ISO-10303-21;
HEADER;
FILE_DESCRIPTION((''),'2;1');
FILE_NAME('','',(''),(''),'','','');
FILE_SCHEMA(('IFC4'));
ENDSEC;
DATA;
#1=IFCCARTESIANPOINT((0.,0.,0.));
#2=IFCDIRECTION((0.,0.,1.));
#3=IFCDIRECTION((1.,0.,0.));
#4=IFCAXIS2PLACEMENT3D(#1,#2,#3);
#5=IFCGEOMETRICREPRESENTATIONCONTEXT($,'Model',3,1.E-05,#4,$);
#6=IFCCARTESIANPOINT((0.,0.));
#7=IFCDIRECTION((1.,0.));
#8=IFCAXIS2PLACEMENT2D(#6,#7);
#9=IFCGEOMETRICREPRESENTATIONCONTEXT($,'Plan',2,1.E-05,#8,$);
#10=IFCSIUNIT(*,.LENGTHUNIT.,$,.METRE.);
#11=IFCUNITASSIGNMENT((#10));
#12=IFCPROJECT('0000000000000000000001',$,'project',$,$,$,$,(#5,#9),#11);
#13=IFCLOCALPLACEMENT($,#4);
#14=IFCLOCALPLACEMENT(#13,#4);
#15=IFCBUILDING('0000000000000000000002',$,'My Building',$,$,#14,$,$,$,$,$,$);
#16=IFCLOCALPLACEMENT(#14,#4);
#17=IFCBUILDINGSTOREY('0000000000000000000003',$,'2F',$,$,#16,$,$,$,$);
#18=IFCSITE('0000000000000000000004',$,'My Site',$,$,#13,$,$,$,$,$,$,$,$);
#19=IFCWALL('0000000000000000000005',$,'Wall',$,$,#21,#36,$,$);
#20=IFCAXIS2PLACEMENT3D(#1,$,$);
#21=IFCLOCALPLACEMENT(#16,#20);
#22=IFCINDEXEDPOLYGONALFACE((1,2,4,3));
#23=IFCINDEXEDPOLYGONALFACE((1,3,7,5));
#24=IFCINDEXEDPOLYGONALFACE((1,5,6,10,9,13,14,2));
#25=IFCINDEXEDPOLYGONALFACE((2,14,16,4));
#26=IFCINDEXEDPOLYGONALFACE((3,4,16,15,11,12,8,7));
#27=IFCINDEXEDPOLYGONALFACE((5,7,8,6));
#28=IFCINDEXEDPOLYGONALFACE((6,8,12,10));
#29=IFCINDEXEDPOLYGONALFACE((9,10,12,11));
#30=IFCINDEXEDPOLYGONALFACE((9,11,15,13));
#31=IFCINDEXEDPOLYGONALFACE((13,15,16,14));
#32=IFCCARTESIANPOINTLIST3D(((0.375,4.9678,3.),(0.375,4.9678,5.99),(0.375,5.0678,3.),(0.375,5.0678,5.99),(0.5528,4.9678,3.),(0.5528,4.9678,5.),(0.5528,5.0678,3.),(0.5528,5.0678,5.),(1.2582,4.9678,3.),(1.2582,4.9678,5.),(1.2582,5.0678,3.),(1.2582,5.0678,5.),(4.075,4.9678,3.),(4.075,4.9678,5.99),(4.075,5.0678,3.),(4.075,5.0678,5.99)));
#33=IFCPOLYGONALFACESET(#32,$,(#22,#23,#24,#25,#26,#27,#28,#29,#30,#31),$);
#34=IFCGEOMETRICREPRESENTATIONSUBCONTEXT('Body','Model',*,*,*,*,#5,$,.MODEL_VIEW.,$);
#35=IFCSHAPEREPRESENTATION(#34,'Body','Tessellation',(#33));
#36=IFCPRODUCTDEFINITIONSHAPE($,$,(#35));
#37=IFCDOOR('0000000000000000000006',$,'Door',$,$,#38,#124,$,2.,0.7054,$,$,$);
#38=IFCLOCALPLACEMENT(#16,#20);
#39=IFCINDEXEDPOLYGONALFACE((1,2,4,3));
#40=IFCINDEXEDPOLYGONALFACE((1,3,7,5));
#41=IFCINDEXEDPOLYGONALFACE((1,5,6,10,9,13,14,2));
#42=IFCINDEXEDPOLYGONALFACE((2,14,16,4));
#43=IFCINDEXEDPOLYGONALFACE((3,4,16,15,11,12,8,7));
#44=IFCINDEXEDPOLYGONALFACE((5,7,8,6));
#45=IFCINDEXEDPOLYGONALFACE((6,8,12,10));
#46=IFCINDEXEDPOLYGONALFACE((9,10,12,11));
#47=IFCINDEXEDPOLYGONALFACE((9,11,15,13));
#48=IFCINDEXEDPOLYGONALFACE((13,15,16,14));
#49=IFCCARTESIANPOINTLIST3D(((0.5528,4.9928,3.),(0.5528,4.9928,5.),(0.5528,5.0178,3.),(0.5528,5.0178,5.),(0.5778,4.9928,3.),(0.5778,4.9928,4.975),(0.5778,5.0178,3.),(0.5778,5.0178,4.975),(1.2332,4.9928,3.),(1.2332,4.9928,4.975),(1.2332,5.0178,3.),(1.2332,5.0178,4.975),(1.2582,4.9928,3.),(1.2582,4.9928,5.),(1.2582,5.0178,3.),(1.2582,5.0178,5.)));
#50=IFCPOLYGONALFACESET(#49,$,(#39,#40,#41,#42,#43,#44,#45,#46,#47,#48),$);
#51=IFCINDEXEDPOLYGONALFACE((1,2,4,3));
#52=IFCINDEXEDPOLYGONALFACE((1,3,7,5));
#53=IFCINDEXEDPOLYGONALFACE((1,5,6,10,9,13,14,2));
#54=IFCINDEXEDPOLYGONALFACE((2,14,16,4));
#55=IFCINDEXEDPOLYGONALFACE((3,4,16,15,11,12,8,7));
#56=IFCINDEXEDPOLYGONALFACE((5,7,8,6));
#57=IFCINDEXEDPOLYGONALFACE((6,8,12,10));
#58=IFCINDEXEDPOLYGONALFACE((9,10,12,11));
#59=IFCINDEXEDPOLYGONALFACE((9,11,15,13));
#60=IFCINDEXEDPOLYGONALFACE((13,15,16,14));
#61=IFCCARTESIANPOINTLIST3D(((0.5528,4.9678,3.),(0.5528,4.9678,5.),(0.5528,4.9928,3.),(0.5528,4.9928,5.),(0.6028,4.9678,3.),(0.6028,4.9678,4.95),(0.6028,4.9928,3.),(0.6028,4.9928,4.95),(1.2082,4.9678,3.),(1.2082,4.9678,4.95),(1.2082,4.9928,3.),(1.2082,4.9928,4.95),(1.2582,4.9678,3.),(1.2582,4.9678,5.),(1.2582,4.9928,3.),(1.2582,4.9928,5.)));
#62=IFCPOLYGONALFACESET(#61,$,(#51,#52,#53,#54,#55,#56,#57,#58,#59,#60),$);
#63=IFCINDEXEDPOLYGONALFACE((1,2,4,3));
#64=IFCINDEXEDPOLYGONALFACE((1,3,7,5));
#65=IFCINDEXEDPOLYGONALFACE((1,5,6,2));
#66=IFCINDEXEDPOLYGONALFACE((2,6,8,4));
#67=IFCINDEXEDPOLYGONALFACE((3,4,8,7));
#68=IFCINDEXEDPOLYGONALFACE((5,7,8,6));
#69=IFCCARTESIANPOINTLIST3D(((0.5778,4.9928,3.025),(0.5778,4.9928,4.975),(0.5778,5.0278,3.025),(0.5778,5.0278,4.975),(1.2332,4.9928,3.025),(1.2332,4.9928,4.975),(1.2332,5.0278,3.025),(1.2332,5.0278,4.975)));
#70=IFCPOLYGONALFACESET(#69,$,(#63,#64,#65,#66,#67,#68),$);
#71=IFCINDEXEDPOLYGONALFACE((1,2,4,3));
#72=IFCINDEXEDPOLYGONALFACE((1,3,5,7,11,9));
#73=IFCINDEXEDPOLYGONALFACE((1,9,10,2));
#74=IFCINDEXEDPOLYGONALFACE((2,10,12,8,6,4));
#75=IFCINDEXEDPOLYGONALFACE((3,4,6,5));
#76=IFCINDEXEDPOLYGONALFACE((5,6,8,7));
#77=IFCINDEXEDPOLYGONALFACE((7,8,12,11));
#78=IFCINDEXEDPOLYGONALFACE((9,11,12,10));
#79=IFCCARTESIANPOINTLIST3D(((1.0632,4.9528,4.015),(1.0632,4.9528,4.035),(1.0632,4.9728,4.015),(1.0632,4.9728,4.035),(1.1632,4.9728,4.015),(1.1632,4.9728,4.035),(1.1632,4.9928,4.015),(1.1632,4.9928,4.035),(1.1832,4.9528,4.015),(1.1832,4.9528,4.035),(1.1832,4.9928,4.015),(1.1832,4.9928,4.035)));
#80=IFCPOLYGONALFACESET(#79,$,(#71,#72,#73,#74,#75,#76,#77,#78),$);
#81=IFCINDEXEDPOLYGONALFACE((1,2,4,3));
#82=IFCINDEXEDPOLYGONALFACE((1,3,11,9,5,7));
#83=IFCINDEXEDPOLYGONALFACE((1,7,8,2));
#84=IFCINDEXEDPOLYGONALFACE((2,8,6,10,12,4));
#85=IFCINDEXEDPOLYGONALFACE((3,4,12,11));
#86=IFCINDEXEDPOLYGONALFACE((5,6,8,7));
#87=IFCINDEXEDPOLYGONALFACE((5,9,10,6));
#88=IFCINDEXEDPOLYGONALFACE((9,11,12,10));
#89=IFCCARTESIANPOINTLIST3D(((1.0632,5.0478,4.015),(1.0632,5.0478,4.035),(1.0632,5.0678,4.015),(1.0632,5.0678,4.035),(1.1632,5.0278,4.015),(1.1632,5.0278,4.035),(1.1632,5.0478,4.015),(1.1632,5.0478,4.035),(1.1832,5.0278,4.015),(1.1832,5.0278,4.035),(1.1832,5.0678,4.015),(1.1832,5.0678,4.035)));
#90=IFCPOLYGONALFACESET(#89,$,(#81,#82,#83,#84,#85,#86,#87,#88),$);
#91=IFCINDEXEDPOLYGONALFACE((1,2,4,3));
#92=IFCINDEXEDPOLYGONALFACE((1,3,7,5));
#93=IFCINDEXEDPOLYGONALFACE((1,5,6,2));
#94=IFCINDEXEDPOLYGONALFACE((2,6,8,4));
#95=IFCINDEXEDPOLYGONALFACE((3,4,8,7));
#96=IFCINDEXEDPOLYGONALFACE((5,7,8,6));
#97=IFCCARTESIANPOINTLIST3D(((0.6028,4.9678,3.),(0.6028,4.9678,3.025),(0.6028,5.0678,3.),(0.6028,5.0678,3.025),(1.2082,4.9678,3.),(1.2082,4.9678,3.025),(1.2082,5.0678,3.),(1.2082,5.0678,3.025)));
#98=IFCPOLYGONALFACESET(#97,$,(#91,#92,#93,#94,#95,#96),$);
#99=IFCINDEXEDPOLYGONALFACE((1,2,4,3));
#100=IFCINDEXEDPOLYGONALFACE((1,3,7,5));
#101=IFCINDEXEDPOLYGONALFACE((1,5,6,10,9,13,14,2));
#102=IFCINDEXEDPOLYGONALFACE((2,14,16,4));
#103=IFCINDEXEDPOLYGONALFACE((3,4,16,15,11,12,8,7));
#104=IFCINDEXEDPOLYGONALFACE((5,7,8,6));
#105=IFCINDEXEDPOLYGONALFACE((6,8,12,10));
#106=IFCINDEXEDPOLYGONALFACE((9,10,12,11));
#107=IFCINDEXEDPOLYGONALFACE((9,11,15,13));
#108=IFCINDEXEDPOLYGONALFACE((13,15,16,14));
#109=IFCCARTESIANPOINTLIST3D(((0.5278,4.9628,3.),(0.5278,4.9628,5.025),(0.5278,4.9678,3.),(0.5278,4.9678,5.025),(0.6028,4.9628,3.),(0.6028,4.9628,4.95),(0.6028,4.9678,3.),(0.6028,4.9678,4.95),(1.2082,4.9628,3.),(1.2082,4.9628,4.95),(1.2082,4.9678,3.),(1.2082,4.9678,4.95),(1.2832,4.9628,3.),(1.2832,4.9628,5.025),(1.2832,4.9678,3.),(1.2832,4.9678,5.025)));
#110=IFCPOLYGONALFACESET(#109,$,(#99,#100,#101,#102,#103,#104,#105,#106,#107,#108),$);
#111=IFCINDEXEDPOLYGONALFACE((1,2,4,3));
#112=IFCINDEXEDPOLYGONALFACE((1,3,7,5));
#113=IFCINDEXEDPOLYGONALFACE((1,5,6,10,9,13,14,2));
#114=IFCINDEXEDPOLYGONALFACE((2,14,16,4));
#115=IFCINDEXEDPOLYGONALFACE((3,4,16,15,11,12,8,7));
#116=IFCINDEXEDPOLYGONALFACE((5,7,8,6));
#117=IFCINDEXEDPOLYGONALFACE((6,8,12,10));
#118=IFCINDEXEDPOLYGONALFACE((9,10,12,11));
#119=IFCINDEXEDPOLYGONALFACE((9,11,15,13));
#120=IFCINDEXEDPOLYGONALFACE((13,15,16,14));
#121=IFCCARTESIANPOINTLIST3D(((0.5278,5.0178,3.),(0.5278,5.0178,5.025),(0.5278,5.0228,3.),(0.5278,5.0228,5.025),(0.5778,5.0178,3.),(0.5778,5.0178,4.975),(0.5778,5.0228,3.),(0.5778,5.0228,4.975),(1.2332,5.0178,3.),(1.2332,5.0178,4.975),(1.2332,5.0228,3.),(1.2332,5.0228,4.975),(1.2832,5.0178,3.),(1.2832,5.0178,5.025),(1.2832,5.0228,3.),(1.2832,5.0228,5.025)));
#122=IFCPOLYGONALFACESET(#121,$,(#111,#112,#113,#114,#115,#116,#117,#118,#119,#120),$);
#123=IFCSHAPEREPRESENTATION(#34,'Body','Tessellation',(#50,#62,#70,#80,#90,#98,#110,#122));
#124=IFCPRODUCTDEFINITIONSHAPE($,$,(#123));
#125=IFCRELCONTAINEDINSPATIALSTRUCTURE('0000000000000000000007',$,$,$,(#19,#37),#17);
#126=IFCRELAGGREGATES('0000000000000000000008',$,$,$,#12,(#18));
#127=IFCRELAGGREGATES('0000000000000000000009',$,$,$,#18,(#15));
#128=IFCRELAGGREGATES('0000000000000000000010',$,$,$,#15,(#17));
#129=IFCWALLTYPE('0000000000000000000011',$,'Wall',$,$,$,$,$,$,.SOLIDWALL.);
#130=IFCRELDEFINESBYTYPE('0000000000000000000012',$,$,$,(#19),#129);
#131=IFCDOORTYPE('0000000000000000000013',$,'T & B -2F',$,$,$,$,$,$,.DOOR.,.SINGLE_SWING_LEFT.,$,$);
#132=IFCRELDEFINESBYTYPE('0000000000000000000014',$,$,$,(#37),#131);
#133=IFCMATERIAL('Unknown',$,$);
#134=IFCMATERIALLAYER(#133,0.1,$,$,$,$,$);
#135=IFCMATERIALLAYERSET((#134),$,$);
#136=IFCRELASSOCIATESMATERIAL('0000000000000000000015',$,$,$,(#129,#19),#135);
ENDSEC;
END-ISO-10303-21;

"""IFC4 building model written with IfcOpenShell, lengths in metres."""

from ifc_helpers import new_model, entity, si_unit, frame, origin_with_axes, origin_2d_with_axis, place, context, subcontext, project, spatial, line, indexed_curve, outline, extrude, shape, source, transform, mapped, material, layer, layer_set, layer_usage, type_object, type_shapes, element, fill, save


model = new_model("IFC4")

# Units and contexts
model_context = context("Model", 3, precision=1e-05, world=origin_with_axes())
plan_context = context("Plan", 2, precision=1e-05, world=origin_2d_with_axis())
body_context_1 = subcontext(model_context, "Body", "Model", "MODEL_VIEW")
body_context_2 = subcontext(plan_context, "Body", "Plan", "PLAN_VIEW")
ifc_project = project(units=[si_unit("LENGTHUNIT", "METRE")], contexts=[model_context, plan_context])

# Site, building, storey
site_placement = place(None, origin_with_axes())
site = spatial("IfcSite", under=ifc_project, at=site_placement, Name="My Site")
building_placement = place(site_placement, origin_with_axes())
building = spatial("IfcBuilding", under=site, at=building_placement, Name="My Building")
storey_placement = place(building_placement, origin_with_axes())
storey = spatial("IfcBuildingStorey", under=building, at=storey_placement, Name="2F")

# Shared definitions
ifc_material = material(Name="Unknown")

# Shared definitions
ifc_layer_1 = layer(ifc_material, 0.1)
ifc_layer_set_1 = layer_set([ifc_layer_1])
wall_type = type_object("IfcWallType", Name="Wall", PredefinedType="SOLIDWALL", material=ifc_layer_set_1)

# Wall, opening, door
ifc_layer_usage_1 = layer_usage(ifc_layer_set_1, "AXIS2", "POSITIVE", 0.0)
wall_1_placement = place(storey_placement, frame((0.375, 4.9678, 3.0), z_axis=(0.0, 0.0, 1.0), x_axis=(1.0, 0.0, 0.0)))
wall_1 = element("IfcWall", 1, at=wall_1_placement, inside=storey, type_object=wall_type, material=ifc_layer_usage_1, Name="Wall", context=body_context_1, shape_type="SweptSolid", body=[
    extrude(outline(indexed_curve([(0.0, 0.0), (0.0, 0.1), (3.7, 0.1), (3.7, 0.0)], segments=[line(1, 2, 3, 4, 1)])), origin_with_axes(), (0.0, 0.0, 1.0), 2.99),
])
shared_shape_1 = source(origin_with_axes(), body_context_1, "Body", "SweptSolid", [
    extrude(outline(indexed_curve([(0.0, 0.0), (0.7054, 0.0), (0.7054, 2.0), (0.0, 2.0)], segments=[line(1, 2, 3, 4, 1)])), frame((0.0, -0.6, 0.0), z_axis=(0.0, -1.0, 0.0), x_axis=(1.0, 0.0, 0.0)), (0.0, 0.0, -1.0), 1.2),
])
opening_1_placement = place(wall_1_placement, frame((0.1778, 0.0, 0.0), z_axis=(0.0, 0.0, 1.0), x_axis=(1.0, 0.0, 0.0)))
opening_1 = element("IfcOpeningElement", 2, at=opening_1_placement, cuts=wall_1, PredefinedType="OPENING", context=body_context_1, shape_type="MappedRepresentation", body=[
    mapped(shared_shape_1, transform((0.0, 0.0, 0.0), x_axis=(1.0, 0.0, 0.0), y_axis=(0.0, 1.0, 0.0), z_axis=(0.0, 0.0, 1.0), scale=1.0)),
])
door_type_1 = type_object("IfcDoorType", Name="T & B -2F", OperationType="SINGLE_SWING_LEFT", PredefinedType="DOOR")
shared_shape_2 = source(origin_with_axes(), body_context_1, "Body", "SweptSolid", [
    extrude(outline(indexed_curve([(0.0, 0.0), (0.0, 2.0), (0.7054, 2.0), (0.7054, 0.0), (0.6804, 0.0), (0.6804, 1.975), (0.025, 1.975), (0.025, 0.0)], segments=[line(1, 2, 3, 4, 5, 6, 7, 8, 1)])), frame((0.0, 0.025, 0.0), z_axis=(0.0, -1.0, 0.0), x_axis=(1.0, 0.0, 0.0)), (0.0, 0.0, -1.0), 0.025),
    extrude(outline(indexed_curve([(0.0, 0.0), (0.0, 2.0), (0.7054, 2.0), (0.7054, 0.0), (0.6554, 0.0), (0.6554, 1.95), (0.05, 1.95), (0.05, 0.0)], segments=[line(1, 2, 3, 4, 5, 6, 7, 8, 1)])), frame((0.0, 0.0, 0.0), z_axis=(0.0, -1.0, 0.0), x_axis=(1.0, 0.0, 0.0)), (0.0, 0.0, -1.0), 0.025),
    extrude(outline(indexed_curve([(0.0, 0.0), (0.6554, 0.0), (0.6554, 0.035), (0.0, 0.035)], segments=[line(1, 2, 3, 4, 1)])), frame((0.025, 0.025, 0.025), z_axis=(0.0, 0.0, 1.0), x_axis=(1.0, 0.0, 0.0)), (0.0, 0.0, 1.0), 1.95),
    extrude(outline(indexed_curve([(0.0, 0.0), (0.0, -0.04), (-0.12, -0.04), (-0.12, -0.02), (-0.02, -0.02), (-0.02, 0.0)], segments=[line(1, 2, 3, 4, 5, 6, 1)])), frame((0.6304, 0.025, 1.015), z_axis=(0.0, 0.0, 1.0), x_axis=(1.0, 0.0, 0.0)), (0.0, 0.0, 1.0), 0.02),
    extrude(outline(indexed_curve([(0.0, 0.0), (0.0, 0.04), (-0.12, 0.04), (-0.12, 0.02), (-0.02, 0.02), (-0.02, 0.0)], segments=[line(1, 2, 3, 4, 5, 6, 1)])), frame((0.6304, 0.06, 1.015), z_axis=(0.0, 0.0, 1.0), x_axis=(1.0, 0.0, 0.0)), (0.0, 0.0, 1.0), 0.02),
    extrude(outline(indexed_curve([(0.0, 0.0), (0.6054, 0.0), (0.6054, 0.1), (0.0, 0.1)], segments=[line(1, 2, 3, 4, 1)])), frame((0.05, 0.0, 0.0), z_axis=(0.0, 0.0, 1.0), x_axis=(1.0, 0.0, 0.0)), (0.0, 0.0, 1.0), 0.025),
    extrude(outline(indexed_curve([(0.0, 0.0), (0.0, 2.025), (0.7554, 2.025), (0.7554, 0.0), (0.6804, 0.0), (0.6804, 1.95), (0.075, 1.95), (0.075, 0.0)], segments=[line(1, 2, 3, 4, 5, 6, 7, 8, 1)])), frame((-0.025, -0.005, 0.0), z_axis=(0.0, -1.0, 0.0), x_axis=(1.0, 0.0, 0.0)), (0.0, 0.0, -1.0), 0.005),
    extrude(outline(indexed_curve([(0.0, 0.0), (0.0, 2.025), (0.7554, 2.025), (0.7554, 0.0), (0.7054, 0.0), (0.7054, 1.975), (0.05, 1.975), (0.05, 0.0)], segments=[line(1, 2, 3, 4, 5, 6, 7, 8, 1)])), frame((-0.025, 0.05, 0.0), z_axis=(0.0, -1.0, 0.0), x_axis=(1.0, 0.0, 0.0)), (0.0, 0.0, -1.0), 0.005),
])
shared_shape_3 = source(origin_with_axes(), body_context_2, "Body", "Curve2D", [
    entity("IfcIndexedPolyCurve", entity("IfcCartesianPointList2D", [[0.0, 0.0], [0.0, 0.05], [0.025, 0.05], [0.025, 0.025], [0.05, 0.025], [0.05, 0.0]]), [entity("IfcLineIndex", [1, 2, 3, 4, 5, 6, 1])]),
    entity("IfcIndexedPolyCurve", entity("IfcCartesianPointList2D", [[0.7054, 0.0], [0.7054, 0.05], [0.6804, 0.05], [0.6804, 0.025], [0.6554, 0.025], [0.6554, 0.0]]), [entity("IfcLineIndex", [1, 2, 3, 4, 5, 6, 1])]),
    entity("IfcTrimmedCurve", entity("IfcEllipse", entity("IfcAxis2Placement2D", entity("IfcCartesianPoint", [0.06, 0.05]), entity("IfcDirection", [1.0, 0.0])), 0.6204, 0.6554), [entity("IfcCartesianPoint", [0.6804, 0.05])], [entity("IfcCartesianPoint", [0.06, 0.7054])], True, "CARTESIAN"),
    entity("IfcIndexedPolyCurve", entity("IfcCartesianPointList2D", [[0.025, 0.05], [0.06, 0.05], [0.06, 0.7054], [0.025, 0.7054]]), [entity("IfcLineIndex", [1, 2, 3, 4, 1])]),
])
type_shapes(door_type_1, [shared_shape_2, shared_shape_3])
door_1_placement = place(opening_1_placement, frame((0.0, 0.0, 0.0), z_axis=(0.0, 0.0, 1.0), x_axis=(1.0, 0.0, 0.0)))
door_1 = element("IfcDoor", 3, at=door_1_placement, inside=storey, type_object=door_type_1, Name="Door", OverallHeight=2.0, OverallWidth=0.7054, shapes=[
    shape(body_context_1, "Body", "MappedRepresentation", [mapped(shared_shape_2, transform((0.0, 0.0, 0.0), x_axis=(1.0, 0.0, 0.0), y_axis=(0.0, 1.0, 0.0), z_axis=(0.0, 0.0, 1.0), scale=1.0))]),
    shape(body_context_2, "Body", "MappedRepresentation", [mapped(shared_shape_3, transform((0.0, 0.0, 0.0), x_axis=(1.0, 0.0, 0.0), y_axis=(0.0, 1.0, 0.0), z_axis=(0.0, 0.0, 1.0), scale=1.0))]),
])
fill(opening_1, door_1)

save(model, "model.ifc")
